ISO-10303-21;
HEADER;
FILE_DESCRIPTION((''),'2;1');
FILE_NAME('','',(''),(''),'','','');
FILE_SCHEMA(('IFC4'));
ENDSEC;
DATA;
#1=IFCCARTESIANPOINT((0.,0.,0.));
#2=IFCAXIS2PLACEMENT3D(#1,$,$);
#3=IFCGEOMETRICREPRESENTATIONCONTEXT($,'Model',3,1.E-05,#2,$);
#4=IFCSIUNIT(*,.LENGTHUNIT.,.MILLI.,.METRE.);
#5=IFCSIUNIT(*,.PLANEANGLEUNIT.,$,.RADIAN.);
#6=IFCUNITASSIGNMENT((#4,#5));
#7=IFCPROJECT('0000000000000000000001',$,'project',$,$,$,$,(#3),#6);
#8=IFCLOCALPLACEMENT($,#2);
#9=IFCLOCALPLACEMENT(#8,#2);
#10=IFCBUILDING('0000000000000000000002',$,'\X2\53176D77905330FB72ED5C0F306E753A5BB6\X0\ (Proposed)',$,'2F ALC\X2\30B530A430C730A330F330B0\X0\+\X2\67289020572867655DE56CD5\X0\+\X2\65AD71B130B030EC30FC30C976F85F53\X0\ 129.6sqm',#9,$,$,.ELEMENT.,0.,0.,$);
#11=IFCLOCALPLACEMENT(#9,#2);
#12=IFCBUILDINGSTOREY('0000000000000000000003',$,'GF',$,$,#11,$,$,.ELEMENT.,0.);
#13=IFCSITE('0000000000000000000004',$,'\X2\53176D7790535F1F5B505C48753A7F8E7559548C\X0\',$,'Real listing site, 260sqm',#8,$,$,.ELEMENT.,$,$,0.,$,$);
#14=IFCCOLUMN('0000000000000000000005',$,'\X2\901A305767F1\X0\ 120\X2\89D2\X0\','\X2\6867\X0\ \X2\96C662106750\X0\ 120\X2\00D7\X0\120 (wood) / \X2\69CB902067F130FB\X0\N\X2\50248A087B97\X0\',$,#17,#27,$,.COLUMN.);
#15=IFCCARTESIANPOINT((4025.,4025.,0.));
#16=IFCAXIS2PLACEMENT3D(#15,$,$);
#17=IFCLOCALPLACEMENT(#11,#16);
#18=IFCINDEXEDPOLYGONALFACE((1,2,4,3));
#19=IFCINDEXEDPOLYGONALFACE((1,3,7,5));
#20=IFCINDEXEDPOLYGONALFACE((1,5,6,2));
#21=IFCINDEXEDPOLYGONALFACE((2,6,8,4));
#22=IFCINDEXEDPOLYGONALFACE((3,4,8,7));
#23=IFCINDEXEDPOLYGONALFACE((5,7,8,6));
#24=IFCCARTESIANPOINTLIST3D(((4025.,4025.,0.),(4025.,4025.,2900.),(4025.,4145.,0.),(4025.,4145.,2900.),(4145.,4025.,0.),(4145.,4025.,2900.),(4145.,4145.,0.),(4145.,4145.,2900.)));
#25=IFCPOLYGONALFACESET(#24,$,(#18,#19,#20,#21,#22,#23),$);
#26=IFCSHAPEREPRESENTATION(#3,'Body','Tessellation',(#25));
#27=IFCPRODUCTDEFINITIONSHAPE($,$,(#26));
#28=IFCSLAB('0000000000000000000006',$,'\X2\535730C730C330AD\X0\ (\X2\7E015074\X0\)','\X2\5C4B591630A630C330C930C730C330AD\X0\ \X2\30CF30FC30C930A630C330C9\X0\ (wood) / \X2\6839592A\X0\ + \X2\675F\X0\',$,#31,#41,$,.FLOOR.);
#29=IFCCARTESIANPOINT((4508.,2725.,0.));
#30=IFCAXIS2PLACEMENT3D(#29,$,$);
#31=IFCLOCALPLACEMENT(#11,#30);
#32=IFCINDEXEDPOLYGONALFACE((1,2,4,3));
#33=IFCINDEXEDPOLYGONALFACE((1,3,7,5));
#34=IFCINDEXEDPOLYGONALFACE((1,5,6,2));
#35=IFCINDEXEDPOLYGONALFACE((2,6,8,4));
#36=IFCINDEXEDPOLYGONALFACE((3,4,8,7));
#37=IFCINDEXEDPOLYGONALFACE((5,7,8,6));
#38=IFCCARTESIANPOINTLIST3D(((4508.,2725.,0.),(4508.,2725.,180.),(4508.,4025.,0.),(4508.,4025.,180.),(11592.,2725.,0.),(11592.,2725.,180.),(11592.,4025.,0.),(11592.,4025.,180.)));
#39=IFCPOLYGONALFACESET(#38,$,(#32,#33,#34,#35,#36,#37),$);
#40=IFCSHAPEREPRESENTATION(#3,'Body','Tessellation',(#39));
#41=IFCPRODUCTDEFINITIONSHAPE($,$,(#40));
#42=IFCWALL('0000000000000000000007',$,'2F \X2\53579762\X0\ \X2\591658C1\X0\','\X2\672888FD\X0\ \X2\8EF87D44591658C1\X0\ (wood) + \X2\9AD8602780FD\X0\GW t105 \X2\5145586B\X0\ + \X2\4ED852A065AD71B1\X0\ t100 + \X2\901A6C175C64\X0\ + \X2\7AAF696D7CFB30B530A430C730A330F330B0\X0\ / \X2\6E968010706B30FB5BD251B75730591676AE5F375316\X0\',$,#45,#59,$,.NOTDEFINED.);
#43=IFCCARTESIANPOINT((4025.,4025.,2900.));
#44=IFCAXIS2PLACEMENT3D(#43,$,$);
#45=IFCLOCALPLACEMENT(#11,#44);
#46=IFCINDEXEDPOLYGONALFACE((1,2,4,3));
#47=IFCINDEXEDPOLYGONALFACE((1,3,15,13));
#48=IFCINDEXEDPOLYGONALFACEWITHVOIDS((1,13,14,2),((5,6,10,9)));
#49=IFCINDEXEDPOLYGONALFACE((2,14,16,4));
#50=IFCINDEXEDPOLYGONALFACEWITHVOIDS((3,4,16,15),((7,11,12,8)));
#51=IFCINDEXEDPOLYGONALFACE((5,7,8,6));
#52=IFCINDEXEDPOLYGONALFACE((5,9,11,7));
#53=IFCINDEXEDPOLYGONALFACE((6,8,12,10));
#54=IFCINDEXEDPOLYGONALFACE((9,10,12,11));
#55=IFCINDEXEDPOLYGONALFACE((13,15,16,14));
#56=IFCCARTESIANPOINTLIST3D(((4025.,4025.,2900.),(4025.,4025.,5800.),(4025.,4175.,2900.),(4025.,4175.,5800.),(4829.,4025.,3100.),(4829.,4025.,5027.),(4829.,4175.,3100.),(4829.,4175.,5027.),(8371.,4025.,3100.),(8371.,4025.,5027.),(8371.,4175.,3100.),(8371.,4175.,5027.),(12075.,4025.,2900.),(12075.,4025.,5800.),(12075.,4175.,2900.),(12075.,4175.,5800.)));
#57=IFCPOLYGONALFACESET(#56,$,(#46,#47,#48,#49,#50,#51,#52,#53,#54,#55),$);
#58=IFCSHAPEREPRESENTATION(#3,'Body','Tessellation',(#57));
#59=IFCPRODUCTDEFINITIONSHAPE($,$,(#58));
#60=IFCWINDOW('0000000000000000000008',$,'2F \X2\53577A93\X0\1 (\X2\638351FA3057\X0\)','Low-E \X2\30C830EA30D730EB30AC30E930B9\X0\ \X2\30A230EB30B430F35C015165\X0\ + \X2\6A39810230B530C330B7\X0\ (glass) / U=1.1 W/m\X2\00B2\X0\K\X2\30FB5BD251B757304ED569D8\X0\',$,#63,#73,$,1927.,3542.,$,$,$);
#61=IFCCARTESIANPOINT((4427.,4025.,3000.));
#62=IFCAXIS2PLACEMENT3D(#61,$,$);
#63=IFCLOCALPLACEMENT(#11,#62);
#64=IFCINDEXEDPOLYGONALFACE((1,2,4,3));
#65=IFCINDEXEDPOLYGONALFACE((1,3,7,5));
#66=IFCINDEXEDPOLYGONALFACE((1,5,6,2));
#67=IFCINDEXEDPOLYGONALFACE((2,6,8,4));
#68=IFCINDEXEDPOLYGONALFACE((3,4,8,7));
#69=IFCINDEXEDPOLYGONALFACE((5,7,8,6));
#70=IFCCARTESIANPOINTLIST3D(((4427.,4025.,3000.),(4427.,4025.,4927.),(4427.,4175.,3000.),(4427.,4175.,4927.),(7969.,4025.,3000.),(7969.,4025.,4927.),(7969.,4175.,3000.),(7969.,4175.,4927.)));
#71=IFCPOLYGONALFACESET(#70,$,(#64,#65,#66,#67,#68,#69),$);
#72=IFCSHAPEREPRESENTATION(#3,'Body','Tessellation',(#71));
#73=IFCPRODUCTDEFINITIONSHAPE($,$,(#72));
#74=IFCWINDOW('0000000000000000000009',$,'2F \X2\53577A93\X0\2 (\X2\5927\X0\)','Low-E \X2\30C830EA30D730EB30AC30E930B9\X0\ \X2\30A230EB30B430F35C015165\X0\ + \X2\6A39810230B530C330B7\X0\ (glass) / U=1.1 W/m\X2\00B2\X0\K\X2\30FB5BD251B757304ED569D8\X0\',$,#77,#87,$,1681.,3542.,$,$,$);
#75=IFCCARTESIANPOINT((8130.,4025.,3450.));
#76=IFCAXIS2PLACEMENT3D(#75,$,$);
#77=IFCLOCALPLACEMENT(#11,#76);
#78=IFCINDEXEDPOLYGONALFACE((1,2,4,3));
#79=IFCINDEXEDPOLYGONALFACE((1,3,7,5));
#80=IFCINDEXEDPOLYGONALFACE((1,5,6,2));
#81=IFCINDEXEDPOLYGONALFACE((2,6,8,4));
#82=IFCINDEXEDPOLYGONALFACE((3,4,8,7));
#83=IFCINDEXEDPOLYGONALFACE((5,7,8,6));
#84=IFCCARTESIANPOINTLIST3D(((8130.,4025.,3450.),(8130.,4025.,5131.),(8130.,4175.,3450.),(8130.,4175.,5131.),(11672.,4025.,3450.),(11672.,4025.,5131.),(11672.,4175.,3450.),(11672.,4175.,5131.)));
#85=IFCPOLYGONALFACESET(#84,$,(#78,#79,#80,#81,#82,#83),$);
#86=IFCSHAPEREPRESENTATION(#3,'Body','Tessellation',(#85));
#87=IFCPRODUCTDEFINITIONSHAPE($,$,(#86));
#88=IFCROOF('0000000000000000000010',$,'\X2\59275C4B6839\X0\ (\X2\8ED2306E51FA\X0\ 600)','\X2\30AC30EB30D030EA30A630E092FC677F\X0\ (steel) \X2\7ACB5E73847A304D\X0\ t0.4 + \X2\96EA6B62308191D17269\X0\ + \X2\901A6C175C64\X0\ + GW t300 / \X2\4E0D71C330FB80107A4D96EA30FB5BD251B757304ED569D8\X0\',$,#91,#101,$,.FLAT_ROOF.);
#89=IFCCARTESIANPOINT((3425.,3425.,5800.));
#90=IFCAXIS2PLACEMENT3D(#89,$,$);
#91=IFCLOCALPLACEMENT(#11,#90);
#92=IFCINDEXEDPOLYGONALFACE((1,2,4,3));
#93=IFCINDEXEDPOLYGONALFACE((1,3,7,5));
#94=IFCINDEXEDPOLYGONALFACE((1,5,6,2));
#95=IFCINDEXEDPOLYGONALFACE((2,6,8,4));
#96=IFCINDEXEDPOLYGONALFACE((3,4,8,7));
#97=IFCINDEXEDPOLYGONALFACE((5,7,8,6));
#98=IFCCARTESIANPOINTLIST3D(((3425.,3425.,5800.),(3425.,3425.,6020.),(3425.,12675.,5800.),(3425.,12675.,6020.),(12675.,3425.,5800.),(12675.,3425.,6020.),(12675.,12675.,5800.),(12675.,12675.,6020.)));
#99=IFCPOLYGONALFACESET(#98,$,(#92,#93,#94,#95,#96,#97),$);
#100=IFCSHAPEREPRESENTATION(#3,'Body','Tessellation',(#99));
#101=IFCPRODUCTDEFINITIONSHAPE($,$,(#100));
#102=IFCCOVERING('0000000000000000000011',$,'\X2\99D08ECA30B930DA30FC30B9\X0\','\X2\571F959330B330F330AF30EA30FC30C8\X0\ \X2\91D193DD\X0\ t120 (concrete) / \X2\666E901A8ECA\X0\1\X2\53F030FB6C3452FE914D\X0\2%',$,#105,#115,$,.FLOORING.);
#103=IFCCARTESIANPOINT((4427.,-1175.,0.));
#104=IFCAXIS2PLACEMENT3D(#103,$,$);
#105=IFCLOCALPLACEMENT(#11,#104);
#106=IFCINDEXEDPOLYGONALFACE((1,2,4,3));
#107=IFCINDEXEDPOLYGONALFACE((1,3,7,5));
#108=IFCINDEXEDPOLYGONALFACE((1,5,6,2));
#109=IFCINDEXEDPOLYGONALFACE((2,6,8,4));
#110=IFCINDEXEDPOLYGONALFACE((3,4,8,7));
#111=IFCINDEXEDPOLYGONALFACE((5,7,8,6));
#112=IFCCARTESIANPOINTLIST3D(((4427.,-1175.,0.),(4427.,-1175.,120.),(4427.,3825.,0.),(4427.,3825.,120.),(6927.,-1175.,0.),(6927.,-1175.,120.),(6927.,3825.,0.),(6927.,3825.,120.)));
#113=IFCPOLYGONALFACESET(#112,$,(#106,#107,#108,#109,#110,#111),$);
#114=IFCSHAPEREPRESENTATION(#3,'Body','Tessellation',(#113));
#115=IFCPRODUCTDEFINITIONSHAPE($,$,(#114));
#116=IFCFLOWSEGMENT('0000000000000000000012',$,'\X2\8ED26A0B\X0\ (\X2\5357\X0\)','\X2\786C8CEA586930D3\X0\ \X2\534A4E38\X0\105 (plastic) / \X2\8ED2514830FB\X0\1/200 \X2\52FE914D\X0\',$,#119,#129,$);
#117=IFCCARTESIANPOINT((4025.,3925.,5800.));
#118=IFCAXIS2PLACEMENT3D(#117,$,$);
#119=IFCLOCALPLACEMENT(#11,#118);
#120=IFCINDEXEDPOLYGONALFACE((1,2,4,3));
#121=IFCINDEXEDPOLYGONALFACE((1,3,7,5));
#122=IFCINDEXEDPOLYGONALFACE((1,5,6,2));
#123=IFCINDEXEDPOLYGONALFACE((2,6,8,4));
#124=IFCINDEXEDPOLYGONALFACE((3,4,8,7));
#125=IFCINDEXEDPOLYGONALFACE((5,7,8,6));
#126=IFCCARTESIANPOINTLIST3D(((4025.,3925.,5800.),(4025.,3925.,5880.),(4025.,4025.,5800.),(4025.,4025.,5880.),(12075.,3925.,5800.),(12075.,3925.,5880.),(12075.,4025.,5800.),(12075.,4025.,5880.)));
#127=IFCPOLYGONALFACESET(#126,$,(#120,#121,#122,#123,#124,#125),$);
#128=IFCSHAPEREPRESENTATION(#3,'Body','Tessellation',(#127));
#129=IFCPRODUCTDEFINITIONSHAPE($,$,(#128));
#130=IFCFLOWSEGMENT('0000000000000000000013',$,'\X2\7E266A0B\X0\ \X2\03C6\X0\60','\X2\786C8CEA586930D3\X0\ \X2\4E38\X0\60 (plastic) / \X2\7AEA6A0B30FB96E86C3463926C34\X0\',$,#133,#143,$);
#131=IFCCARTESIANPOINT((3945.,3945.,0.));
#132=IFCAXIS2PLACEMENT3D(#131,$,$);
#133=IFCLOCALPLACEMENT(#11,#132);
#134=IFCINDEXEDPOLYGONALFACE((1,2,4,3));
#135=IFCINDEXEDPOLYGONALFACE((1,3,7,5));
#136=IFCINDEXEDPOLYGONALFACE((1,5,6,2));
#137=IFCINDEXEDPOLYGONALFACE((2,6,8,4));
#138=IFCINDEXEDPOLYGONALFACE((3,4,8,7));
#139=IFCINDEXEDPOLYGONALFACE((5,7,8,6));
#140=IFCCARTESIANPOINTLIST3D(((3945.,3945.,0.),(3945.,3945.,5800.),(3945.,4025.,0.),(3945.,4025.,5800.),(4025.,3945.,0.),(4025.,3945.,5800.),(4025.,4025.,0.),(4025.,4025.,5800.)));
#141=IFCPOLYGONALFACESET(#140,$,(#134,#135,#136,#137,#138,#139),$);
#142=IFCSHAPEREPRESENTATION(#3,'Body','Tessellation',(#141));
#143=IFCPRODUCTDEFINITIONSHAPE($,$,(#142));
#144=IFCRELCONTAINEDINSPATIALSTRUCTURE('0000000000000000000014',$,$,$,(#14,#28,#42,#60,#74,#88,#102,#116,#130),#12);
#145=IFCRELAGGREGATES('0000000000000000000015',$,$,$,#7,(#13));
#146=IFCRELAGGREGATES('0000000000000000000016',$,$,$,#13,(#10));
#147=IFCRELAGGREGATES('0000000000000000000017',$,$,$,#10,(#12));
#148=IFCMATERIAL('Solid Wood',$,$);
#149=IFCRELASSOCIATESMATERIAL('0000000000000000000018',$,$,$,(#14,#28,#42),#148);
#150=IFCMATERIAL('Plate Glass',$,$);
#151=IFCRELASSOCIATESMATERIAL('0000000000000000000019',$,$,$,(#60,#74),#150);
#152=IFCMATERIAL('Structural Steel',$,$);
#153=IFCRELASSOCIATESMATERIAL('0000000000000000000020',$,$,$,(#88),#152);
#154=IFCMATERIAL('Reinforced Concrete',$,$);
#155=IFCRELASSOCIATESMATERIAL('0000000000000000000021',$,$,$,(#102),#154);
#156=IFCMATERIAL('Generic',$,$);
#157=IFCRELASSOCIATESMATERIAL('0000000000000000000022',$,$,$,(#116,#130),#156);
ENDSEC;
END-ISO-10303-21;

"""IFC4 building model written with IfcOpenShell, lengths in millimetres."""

from ifc_helpers import new_model, si_unit, frame, frame_2d, origin, place, context, project, spatial, rectangle, extrude, material, element, fill, save


model = new_model("IFC4")

# Units and contexts
model_context = context("Model", 3, precision=1e-05, world=origin())
ifc_project = project(units=[si_unit("LENGTHUNIT", "METRE", prefix="MILLI"), si_unit("PLANEANGLEUNIT", "RADIAN")], contexts=[model_context])

# Site, building, storey
site_placement = place(None, origin())
site = spatial("IfcSite", under=ifc_project, at=site_placement, Name="北海道弟子屈町美留和", ObjectType="Real listing site, 260sqm", CompositionType="ELEMENT", RefElevation=0.0)
building_placement = place(site_placement, origin())
building = spatial("IfcBuilding", under=site, at=building_placement, Name="北海道・狭小の町家 (Proposed)", ObjectType="2F ALCサイディング+木造在来工法+断熱グレード相当 129.6sqm", CompositionType="ELEMENT", ElevationOfRefHeight=0.0, ElevationOfTerrain=0.0)
storey_placement = place(building_placement, origin())
storey = spatial("IfcBuildingStorey", under=building, at=storey_placement, Name="GF", CompositionType="ELEMENT", Elevation=0.0)

# Column
ifc_material_1 = material(Name="Solid Wood")
column_placement = place(storey_placement, frame((4025.0, 4025.0, 0.0)))
element("IfcColumn", 1, at=column_placement, inside=storey, material=ifc_material_1, Name="通し柱 120角", Description="桧 集成材 120×120 (wood) / 構造柱・N値計算", PredefinedType="COLUMN", context=model_context, shape_type="SweptSolid", body=[
    extrude(rectangle(XDim=120.0, YDim=120.0, at=frame_2d((60.0, 60.0))), frame((4025.0, 4025.0, 0.0)), (0.0, 0.0, 1.0), 2900.0),
])

# Slab
ifc_material_2 = material(Name="Reinforced Concrete")
slab_1_placement = place(storey_placement, frame((4508.0, 2725.0, 0.0)))
element("IfcSlab", 2, at=slab_1_placement, inside=storey, material=ifc_material_1, Name="南デッキ (縁側)", Description="屋外ウッドデッキ ハードウッド (wood) / 根太 + 束", PredefinedType="FLOOR", context=model_context, shape_type="SweptSolid", body=[
    extrude(rectangle(XDim=7084.0, YDim=1300.0, at=frame_2d((3542.0, 650.0))), frame((4508.0, 2725.0, 0.0)), (0.0, 0.0, 1.0), 180.0),
])

# Shared definitions
ifc_material_3 = material(Name="Plate Glass")

# Wall, openings, windows
wall_1_placement = place(storey_placement, frame((4025.0, 4025.0, 2900.0)))
wall_1 = element("IfcWall", 3, at=wall_1_placement, inside=storey, material=ifc_material_1, Name="2F 南面 外壁", Description="木製 軸組外壁 (wood) + 高性能GW t105 充填 + 付加断熱 t100 + 通気層 + 窯業系サイディング / 準耐火・寒冷地外皮強化", PredefinedType="NOTDEFINED", context=model_context, shape_type="SweptSolid", body=[
    extrude(rectangle(XDim=8050.0, YDim=150.0, at=frame_2d((4025.0, 75.0))), frame((4025.0, 4025.0, 2900.0)), (0.0, 0.0, 1.0), 2900.0),
])
opening_1_placement = place(storey_placement, frame((4427.0, 4025.0, 3000.0)))
opening_1 = element("IfcOpeningElement", 4, at=opening_1_placement, cuts=wall_1, PredefinedType="NOTDEFINED", context=model_context, shape_type="SweptSolid", body=[
    extrude(rectangle(XDim=3542.0, YDim=150.0, at=frame_2d((1771.0, 75.0))), frame((4427.0, 4025.0, 3000.0)), (0.0, 0.0, 1.0), 1927.0),
])
opening_2_placement = place(storey_placement, frame((8130.0, 4025.0, 3450.0)))
opening_2 = element("IfcOpeningElement", 5, at=opening_2_placement, cuts=wall_1, PredefinedType="NOTDEFINED", context=model_context, shape_type="SweptSolid", body=[
    extrude(rectangle(XDim=3542.0, YDim=150.0, at=frame_2d((1771.0, 75.0))), frame((8130.0, 4025.0, 3450.0)), (0.0, 0.0, 1.0), 1681.0),
])
window_1_placement = place(storey_placement, frame((4427.0, 4025.0, 3000.0)))
window_1 = element("IfcWindow", 6, at=window_1_placement, inside=storey, material=ifc_material_3, Name="2F 南窓1 (掃出し)", Description="Low-E トリプルガラス アルゴン封入 + 樹脂サッシ (glass) / U=1.1 W/m²K・寒冷地仕様", OverallHeight=1927.0, OverallWidth=3542.0, context=model_context, shape_type="SweptSolid", body=[
    extrude(rectangle(XDim=3542.0, YDim=150.0, at=frame_2d((1771.0, 75.0))), frame((4427.0, 4025.0, 3000.0)), (0.0, 0.0, 1.0), 1927.0),
])
fill(opening_1, window_1)
window_2_placement = place(storey_placement, frame((8130.0, 4025.0, 3450.0)))
window_2 = element("IfcWindow", 7, at=window_2_placement, inside=storey, material=ifc_material_3, Name="2F 南窓2 (大)", Description="Low-E トリプルガラス アルゴン封入 + 樹脂サッシ (glass) / U=1.1 W/m²K・寒冷地仕様", OverallHeight=1681.0, OverallWidth=3542.0, context=model_context, shape_type="SweptSolid", body=[
    extrude(rectangle(XDim=3542.0, YDim=150.0, at=frame_2d((1771.0, 75.0))), frame((8130.0, 4025.0, 3450.0)), (0.0, 0.0, 1.0), 1681.0),
])
fill(opening_2, window_2)

# Roof
ifc_material_4 = material(Name="Structural Steel")
roof_placement = place(storey_placement, frame((3425.0, 3425.0, 5800.0)))
element("IfcRoof", 8, at=roof_placement, inside=storey, material=ifc_material_4, Name="大屋根 (軒の出 600)", Description="ガルバリウム鋼板 (steel) 立平葺き t0.4 + 雪止め金物 + 通気層 + GW t300 / 不燃・耐積雪・寒冷地仕様", PredefinedType="FLAT_ROOF", context=model_context, shape_type="SweptSolid", body=[
    extrude(rectangle(XDim=9250.0, YDim=9250.0, at=frame_2d((4625.0, 4625.0))), frame((3425.0, 3425.0, 5800.0)), (0.0, 0.0, 1.0), 220.0),
])

# Covering
covering_placement = place(storey_placement, frame((4427.0, -1175.0, 0.0)))
element("IfcCovering", 9, at=covering_placement, inside=storey, material=ifc_material_2, Name="駐車スペース", Description="土間コンクリート 金鏝 t120 (concrete) / 普通車1台・水勾配2%", PredefinedType="FLOORING", context=model_context, shape_type="SweptSolid", body=[
    extrude(rectangle(XDim=2500.0, YDim=5000.0, at=frame_2d((1250.0, 2500.0))), frame((4427.0, -1175.0, 0.0)), (0.0, 0.0, 1.0), 120.0),
])

# Flow segments
ifc_material_5 = material(Name="Generic")
flow_segment_1_placement = place(storey_placement, frame((4025.0, 3925.0, 5800.0)))
element("IfcFlowSegment", 10, at=flow_segment_1_placement, inside=storey, material=ifc_material_5, Name="軒樋 (南)", Description="硬質塩ビ 半丸105 (plastic) / 軒先・1/200 勾配", context=model_context, shape_type="SweptSolid", body=[
    extrude(rectangle(XDim=8050.0, YDim=100.0, at=frame_2d((4025.0, 50.0))), frame((4025.0, 3925.0, 5800.0)), (0.0, 0.0, 1.0), 80.0),
])
flow_segment_2_placement = place(storey_placement, frame((3945.0, 3945.0, 0.0)))
element("IfcFlowSegment", 11, at=flow_segment_2_placement, inside=storey, material=ifc_material_5, Name="縦樋 φ60", Description="硬質塩ビ 丸60 (plastic) / 竪樋・雨水排水", context=model_context, shape_type="SweptSolid", body=[
    extrude(rectangle(XDim=80.0, YDim=80.0, at=frame_2d((40.0, 40.0))), frame((3945.0, 3945.0, 0.0)), (0.0, 0.0, 1.0), 5800.0),
])

save(model, "model.ifc")
